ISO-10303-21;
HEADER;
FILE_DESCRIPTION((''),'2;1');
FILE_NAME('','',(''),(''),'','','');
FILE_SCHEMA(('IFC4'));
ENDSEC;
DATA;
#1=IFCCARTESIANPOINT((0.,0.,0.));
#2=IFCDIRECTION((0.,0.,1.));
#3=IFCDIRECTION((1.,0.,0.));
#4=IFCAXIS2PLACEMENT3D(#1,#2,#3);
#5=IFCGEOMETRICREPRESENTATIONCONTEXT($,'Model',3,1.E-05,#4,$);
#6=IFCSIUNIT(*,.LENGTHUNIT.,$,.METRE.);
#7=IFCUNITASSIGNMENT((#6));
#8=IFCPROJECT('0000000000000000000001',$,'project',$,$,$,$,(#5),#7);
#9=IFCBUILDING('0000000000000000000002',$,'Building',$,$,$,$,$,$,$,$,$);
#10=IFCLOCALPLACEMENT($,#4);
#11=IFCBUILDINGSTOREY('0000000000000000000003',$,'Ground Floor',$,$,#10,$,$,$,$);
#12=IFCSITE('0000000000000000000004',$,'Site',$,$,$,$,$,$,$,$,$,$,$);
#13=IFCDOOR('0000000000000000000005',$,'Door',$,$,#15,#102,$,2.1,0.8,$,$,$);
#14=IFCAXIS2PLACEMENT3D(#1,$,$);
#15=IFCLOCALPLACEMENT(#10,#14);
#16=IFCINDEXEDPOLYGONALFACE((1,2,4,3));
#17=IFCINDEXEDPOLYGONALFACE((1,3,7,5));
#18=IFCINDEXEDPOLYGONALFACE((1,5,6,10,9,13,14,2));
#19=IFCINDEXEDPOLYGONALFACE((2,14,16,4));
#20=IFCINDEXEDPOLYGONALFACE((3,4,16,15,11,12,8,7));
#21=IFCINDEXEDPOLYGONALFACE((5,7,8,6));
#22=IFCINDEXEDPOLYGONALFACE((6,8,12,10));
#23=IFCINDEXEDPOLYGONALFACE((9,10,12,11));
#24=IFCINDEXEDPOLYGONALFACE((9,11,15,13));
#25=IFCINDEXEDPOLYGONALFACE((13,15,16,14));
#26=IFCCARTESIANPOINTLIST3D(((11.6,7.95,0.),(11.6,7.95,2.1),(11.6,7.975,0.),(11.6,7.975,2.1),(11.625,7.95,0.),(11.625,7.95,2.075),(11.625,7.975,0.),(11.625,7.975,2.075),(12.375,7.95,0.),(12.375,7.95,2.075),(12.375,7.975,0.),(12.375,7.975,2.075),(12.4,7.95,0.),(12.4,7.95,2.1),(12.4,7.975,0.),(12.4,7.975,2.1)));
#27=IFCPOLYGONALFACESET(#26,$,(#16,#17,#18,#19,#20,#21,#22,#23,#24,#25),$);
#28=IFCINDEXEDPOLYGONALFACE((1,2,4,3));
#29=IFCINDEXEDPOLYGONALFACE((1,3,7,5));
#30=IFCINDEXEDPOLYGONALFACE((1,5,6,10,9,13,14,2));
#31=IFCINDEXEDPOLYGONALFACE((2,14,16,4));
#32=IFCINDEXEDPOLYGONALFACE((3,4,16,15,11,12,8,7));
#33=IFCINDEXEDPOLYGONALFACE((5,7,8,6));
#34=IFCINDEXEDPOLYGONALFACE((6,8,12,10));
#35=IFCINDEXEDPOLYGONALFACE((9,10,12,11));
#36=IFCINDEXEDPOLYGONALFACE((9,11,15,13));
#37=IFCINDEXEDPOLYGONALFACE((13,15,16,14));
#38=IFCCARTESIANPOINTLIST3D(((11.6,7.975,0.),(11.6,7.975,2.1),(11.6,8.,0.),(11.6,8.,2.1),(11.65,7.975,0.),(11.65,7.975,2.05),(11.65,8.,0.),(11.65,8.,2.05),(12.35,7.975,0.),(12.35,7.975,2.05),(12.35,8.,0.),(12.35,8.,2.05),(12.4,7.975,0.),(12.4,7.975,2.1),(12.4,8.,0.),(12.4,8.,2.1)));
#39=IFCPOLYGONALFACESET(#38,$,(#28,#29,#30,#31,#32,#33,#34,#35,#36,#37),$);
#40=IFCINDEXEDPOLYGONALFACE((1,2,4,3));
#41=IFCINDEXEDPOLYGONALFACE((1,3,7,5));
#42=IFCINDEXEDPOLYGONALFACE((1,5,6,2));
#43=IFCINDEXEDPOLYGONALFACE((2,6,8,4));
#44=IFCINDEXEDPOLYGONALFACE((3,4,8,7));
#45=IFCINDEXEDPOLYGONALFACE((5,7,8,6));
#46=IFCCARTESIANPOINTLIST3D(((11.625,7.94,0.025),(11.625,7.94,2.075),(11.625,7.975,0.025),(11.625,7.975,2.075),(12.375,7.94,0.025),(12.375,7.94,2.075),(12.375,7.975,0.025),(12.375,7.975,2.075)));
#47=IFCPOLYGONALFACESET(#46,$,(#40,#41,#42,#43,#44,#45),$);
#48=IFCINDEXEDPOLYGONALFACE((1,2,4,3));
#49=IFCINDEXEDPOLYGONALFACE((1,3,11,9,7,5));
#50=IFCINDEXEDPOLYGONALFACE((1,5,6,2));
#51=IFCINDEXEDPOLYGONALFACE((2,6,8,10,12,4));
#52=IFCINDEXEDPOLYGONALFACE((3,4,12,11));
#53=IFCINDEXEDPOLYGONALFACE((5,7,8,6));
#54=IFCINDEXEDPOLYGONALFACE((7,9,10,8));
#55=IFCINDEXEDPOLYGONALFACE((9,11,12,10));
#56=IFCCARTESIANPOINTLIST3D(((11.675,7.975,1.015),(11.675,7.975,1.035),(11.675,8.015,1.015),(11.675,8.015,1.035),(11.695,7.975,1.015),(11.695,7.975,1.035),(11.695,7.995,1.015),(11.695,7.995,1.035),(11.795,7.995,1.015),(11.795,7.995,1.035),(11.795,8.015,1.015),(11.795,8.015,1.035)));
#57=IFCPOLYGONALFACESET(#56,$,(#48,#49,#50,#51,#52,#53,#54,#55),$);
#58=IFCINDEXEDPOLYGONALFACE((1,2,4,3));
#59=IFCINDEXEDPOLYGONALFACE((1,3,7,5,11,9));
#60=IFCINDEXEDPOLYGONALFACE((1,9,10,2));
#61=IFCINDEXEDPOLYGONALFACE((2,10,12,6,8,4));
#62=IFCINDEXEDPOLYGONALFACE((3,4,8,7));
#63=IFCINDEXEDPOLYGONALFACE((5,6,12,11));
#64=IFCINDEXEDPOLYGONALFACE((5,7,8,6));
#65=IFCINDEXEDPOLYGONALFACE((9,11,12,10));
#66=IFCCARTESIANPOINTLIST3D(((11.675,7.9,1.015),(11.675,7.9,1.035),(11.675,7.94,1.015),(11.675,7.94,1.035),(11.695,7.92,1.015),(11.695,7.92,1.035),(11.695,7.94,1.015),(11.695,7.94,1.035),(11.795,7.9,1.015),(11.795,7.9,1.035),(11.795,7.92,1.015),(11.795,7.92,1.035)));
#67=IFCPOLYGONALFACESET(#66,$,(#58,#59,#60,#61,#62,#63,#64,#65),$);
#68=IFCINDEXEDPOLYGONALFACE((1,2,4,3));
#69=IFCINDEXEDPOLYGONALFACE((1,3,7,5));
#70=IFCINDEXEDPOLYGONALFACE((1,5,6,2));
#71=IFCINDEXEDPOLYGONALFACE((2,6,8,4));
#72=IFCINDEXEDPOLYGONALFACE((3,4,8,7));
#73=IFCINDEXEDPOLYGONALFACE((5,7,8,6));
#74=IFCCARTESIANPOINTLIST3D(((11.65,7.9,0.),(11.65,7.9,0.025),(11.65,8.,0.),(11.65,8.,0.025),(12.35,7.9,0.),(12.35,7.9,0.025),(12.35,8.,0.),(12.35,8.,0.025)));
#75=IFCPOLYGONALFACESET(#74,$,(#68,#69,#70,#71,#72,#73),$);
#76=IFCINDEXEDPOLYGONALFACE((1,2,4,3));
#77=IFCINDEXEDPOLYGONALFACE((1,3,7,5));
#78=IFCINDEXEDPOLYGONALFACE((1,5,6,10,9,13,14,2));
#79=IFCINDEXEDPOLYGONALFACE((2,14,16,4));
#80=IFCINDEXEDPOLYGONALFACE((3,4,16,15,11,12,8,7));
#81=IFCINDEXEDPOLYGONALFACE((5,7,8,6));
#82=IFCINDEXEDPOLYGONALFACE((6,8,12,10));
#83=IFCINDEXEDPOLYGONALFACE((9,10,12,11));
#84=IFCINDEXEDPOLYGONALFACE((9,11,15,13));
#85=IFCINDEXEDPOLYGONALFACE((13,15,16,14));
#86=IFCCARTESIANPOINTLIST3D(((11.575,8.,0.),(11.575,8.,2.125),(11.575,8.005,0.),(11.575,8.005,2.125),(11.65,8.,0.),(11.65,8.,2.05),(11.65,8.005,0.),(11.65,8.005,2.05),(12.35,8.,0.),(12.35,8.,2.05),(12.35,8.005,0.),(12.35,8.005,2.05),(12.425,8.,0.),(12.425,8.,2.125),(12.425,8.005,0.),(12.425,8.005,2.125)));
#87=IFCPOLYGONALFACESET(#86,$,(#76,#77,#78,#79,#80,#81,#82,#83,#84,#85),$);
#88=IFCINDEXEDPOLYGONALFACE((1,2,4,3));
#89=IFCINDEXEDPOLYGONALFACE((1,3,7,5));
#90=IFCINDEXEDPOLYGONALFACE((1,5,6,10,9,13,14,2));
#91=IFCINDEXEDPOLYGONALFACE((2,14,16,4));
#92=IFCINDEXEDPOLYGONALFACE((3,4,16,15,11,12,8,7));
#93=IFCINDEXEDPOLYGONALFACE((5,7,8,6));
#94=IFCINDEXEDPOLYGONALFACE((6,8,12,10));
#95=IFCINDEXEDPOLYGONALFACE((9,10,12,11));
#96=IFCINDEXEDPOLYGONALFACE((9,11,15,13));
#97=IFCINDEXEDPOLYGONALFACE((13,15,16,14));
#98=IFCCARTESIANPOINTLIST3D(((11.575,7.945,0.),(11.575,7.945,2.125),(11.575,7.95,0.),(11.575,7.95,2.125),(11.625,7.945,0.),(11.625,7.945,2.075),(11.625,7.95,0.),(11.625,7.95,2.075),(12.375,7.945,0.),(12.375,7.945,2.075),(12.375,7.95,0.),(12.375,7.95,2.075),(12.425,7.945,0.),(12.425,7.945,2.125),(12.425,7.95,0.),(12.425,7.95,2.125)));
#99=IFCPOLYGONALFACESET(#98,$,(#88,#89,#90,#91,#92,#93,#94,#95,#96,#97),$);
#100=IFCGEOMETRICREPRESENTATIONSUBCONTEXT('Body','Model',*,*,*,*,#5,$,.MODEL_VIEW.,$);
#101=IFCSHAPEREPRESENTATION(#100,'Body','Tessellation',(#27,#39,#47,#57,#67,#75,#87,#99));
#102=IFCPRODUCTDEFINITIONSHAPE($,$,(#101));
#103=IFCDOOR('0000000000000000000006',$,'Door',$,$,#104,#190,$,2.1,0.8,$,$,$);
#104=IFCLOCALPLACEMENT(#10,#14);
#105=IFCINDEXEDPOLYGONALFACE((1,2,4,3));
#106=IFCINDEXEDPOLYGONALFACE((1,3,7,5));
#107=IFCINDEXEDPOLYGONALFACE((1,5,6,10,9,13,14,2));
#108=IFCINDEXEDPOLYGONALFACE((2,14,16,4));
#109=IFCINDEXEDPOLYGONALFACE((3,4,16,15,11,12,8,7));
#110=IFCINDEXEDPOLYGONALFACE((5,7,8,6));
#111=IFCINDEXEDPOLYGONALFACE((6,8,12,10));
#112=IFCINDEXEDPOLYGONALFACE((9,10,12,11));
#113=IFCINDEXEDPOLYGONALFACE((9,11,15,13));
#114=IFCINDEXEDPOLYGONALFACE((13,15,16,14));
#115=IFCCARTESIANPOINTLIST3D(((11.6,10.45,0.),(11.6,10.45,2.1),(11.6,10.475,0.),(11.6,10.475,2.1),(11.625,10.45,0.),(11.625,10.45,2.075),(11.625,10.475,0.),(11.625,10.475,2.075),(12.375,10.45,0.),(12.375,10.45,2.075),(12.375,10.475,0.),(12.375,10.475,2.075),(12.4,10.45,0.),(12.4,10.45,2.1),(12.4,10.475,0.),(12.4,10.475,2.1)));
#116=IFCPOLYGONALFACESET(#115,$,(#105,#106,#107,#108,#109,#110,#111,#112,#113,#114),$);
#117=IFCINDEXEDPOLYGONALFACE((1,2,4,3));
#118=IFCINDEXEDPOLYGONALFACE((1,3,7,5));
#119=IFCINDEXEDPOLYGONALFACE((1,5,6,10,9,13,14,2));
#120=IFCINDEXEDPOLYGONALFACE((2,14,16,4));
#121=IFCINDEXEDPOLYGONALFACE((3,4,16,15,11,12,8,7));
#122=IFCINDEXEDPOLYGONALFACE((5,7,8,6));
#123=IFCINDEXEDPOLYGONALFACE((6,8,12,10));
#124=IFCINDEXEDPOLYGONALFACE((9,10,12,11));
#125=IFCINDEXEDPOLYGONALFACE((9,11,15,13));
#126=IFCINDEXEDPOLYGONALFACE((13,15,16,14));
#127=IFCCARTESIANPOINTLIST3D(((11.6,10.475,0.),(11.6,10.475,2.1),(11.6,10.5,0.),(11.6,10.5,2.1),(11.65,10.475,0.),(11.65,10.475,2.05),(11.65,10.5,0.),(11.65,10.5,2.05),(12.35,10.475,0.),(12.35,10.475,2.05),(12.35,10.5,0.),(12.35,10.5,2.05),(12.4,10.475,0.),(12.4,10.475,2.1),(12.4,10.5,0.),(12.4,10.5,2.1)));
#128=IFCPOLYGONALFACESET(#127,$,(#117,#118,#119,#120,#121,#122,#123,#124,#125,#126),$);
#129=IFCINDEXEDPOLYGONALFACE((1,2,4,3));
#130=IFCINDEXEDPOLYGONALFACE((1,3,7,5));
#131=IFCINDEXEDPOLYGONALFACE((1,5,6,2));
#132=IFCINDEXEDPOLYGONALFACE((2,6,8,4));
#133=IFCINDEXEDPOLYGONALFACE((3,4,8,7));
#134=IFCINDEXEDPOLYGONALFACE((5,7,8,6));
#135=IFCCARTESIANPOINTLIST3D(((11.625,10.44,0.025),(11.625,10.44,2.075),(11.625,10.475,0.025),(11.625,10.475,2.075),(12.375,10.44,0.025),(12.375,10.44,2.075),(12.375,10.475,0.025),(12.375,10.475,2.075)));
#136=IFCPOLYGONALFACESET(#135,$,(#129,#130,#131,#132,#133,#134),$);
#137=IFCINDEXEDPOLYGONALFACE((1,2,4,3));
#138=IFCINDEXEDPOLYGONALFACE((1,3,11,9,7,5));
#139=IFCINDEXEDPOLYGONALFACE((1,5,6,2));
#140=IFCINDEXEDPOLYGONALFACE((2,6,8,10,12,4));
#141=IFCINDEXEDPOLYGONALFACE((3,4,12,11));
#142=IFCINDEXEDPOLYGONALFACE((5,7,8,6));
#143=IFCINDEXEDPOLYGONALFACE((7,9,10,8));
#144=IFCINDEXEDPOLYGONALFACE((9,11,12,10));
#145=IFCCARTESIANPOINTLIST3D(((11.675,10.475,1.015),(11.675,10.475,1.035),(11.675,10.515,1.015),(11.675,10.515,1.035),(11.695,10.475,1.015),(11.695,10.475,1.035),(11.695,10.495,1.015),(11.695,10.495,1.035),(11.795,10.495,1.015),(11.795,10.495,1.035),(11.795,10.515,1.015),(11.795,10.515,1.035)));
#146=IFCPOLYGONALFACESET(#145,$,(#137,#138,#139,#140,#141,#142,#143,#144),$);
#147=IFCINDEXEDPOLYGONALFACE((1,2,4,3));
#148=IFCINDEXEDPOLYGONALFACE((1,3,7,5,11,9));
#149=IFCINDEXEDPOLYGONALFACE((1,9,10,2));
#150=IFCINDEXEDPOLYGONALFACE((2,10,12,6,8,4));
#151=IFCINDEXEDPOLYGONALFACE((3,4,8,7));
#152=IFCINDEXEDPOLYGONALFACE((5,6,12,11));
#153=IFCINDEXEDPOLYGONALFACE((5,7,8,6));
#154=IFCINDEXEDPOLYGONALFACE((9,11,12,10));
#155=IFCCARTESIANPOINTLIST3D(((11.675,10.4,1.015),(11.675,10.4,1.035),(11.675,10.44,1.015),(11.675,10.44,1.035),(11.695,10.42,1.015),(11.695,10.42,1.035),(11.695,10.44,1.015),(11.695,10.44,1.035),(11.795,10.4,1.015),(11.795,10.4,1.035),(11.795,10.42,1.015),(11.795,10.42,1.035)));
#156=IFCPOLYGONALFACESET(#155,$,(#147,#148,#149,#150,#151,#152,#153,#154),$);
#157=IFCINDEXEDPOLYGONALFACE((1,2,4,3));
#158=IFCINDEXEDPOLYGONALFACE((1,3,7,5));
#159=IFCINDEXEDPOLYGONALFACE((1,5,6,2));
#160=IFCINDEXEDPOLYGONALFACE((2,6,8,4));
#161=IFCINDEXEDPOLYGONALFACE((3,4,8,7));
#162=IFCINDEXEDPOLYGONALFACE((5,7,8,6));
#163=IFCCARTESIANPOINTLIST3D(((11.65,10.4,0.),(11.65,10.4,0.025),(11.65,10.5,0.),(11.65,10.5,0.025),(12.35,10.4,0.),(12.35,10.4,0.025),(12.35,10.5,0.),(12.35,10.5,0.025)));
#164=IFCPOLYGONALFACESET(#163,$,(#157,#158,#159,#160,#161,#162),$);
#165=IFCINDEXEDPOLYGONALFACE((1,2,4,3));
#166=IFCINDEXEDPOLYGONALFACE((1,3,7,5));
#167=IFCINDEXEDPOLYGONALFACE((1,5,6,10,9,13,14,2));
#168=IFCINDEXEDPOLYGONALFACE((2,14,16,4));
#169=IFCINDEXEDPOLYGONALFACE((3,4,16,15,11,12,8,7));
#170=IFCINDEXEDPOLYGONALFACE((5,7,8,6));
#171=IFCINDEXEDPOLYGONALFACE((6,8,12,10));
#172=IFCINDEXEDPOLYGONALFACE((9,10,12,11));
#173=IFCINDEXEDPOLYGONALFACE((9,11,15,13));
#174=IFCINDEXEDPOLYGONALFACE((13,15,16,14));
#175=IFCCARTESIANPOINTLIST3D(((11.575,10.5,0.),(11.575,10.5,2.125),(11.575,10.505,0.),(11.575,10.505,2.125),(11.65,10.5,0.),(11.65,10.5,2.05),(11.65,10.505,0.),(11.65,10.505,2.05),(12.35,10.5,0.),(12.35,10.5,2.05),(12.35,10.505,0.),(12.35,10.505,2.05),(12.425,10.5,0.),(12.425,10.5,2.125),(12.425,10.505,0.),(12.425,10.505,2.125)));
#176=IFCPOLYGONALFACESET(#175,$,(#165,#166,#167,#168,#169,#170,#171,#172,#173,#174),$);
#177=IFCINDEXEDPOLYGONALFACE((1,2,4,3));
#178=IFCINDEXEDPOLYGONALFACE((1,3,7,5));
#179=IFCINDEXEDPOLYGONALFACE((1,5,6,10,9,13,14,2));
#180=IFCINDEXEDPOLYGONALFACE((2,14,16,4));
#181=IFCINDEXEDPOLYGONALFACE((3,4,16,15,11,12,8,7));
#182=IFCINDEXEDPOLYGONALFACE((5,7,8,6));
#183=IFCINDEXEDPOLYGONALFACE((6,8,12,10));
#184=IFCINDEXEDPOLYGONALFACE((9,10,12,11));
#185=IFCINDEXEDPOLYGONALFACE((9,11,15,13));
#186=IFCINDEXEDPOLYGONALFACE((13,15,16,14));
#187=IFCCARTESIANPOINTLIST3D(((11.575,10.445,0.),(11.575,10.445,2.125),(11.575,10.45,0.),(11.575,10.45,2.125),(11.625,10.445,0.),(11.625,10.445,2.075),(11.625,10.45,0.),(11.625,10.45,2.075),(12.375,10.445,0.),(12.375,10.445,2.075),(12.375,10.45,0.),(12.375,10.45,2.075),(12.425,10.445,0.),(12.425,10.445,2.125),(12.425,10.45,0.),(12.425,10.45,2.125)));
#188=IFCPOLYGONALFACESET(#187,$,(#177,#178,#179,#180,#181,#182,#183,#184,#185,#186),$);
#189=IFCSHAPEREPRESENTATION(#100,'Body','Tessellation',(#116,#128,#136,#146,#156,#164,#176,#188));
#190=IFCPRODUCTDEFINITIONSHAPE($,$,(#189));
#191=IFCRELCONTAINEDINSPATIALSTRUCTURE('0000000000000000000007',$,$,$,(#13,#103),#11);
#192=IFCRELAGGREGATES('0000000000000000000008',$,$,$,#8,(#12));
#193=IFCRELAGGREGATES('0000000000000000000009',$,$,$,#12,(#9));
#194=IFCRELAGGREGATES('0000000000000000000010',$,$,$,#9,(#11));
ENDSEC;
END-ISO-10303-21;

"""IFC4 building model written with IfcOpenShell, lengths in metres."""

from ifc_helpers import new_model, si_unit, frame, origin_with_axes, place, context, subcontext, project, spatial, line, indexed_curve, outline, extrude, element, save


model = new_model("IFC4")

# Units and contexts
model_context = context("Model", 3, precision=1e-05, world=origin_with_axes())
body_context = subcontext(model_context, "Body", "Model", "MODEL_VIEW")
ifc_project = project(units=[si_unit("LENGTHUNIT", "METRE")], contexts=[model_context])

# Site, building, storey
site = spatial("IfcSite", under=ifc_project, Name="Site")
building = spatial("IfcBuilding", under=site, Name="Building")
storey_placement = place(None, origin_with_axes())
storey = spatial("IfcBuildingStorey", under=building, at=storey_placement, Name="Ground Floor")

# Doors
door_1_placement = place(storey_placement, frame((12.4, 8.0, 0.0), z_axis=(0.0, 0.0, 1.0), x_axis=(-1.0, 0.0, 0.0)))
element("IfcDoor", 1, at=door_1_placement, inside=storey, Name="Door", OverallHeight=2.1, OverallWidth=0.8, context=body_context, shape_type="SweptSolid", body=[
    extrude(outline(indexed_curve([(0.0, 0.0), (0.0, 2.1), (0.8, 2.1), (0.8, 0.0), (0.775, 0.0), (0.775, 2.075), (0.025, 2.075), (0.025, 0.0)], segments=[line(1, 2, 3, 4, 5, 6, 7, 8, 1)])), frame((0.0, 0.025, 0.0), z_axis=(0.0, -1.0, 0.0), x_axis=(1.0, 0.0, 0.0)), (0.0, 0.0, -1.0), 0.025),
    extrude(outline(indexed_curve([(0.0, 0.0), (0.0, 2.1), (0.8, 2.1), (0.8, 0.0), (0.75, 0.0), (0.75, 2.05), (0.05, 2.05), (0.05, 0.0)], segments=[line(1, 2, 3, 4, 5, 6, 7, 8, 1)])), frame((0.0, 0.0, 0.0), z_axis=(0.0, -1.0, 0.0), x_axis=(1.0, 0.0, 0.0)), (0.0, 0.0, -1.0), 0.025),
    extrude(outline(indexed_curve([(0.0, 0.0), (0.75, 0.0), (0.75, 0.035), (0.0, 0.035)], segments=[line(1, 2, 3, 4, 1)])), frame((0.025, 0.025, 0.025), z_axis=(0.0, 0.0, 1.0), x_axis=(1.0, 0.0, 0.0)), (0.0, 0.0, 1.0), 2.05),
    extrude(outline(indexed_curve([(0.0, 0.0), (0.0, -0.04), (-0.12, -0.04), (-0.12, -0.02), (-0.02, -0.02), (-0.02, 0.0)], segments=[line(1, 2, 3, 4, 5, 6, 1)])), frame((0.725, 0.025, 1.015), z_axis=(0.0, 0.0, 1.0), x_axis=(1.0, 0.0, 0.0)), (0.0, 0.0, 1.0), 0.02),
    extrude(outline(indexed_curve([(0.0, 0.0), (0.0, 0.04), (-0.12, 0.04), (-0.12, 0.02), (-0.02, 0.02), (-0.02, 0.0)], segments=[line(1, 2, 3, 4, 5, 6, 1)])), frame((0.725, 0.06, 1.015), z_axis=(0.0, 0.0, 1.0), x_axis=(1.0, 0.0, 0.0)), (0.0, 0.0, 1.0), 0.02),
    extrude(outline(indexed_curve([(0.0, 0.0), (0.7, 0.0), (0.7, 0.1), (0.0, 0.1)], segments=[line(1, 2, 3, 4, 1)])), frame((0.05, 0.0, 0.0), z_axis=(0.0, 0.0, 1.0), x_axis=(1.0, 0.0, 0.0)), (0.0, 0.0, 1.0), 0.025),
    extrude(outline(indexed_curve([(0.0, 0.0), (0.0, 2.125), (0.85, 2.125), (0.85, 0.0), (0.775, 0.0), (0.775, 2.05), (0.075, 2.05), (0.075, 0.0)], segments=[line(1, 2, 3, 4, 5, 6, 7, 8, 1)])), frame((-0.025, -0.005, 0.0), z_axis=(0.0, -1.0, 0.0), x_axis=(1.0, 0.0, 0.0)), (0.0, 0.0, -1.0), 0.005),
    extrude(outline(indexed_curve([(0.0, 0.0), (0.0, 2.125), (0.85, 2.125), (0.85, 0.0), (0.8, 0.0), (0.8, 2.075), (0.05, 2.075), (0.05, 0.0)], segments=[line(1, 2, 3, 4, 5, 6, 7, 8, 1)])), frame((-0.025, 0.05, 0.0), z_axis=(0.0, -1.0, 0.0), x_axis=(1.0, 0.0, 0.0)), (0.0, 0.0, -1.0), 0.005),
])
door_2_placement = place(storey_placement, frame((12.4, 10.5, 0.0), z_axis=(0.0, 0.0, 1.0), x_axis=(-1.0, 0.0, 0.0)))
element("IfcDoor", 2, at=door_2_placement, inside=storey, Name="Door", OverallHeight=2.1, OverallWidth=0.8, context=body_context, shape_type="SweptSolid", body=[
    extrude(outline(indexed_curve([(0.0, 0.0), (0.0, 2.1), (0.8, 2.1), (0.8, 0.0), (0.775, 0.0), (0.775, 2.075), (0.025, 2.075), (0.025, 0.0)], segments=[line(1, 2, 3, 4, 5, 6, 7, 8, 1)])), frame((0.0, 0.025, 0.0), z_axis=(0.0, -1.0, 0.0), x_axis=(1.0, 0.0, 0.0)), (0.0, 0.0, -1.0), 0.025),
    extrude(outline(indexed_curve([(0.0, 0.0), (0.0, 2.1), (0.8, 2.1), (0.8, 0.0), (0.75, 0.0), (0.75, 2.05), (0.05, 2.05), (0.05, 0.0)], segments=[line(1, 2, 3, 4, 5, 6, 7, 8, 1)])), frame((0.0, 0.0, 0.0), z_axis=(0.0, -1.0, 0.0), x_axis=(1.0, 0.0, 0.0)), (0.0, 0.0, -1.0), 0.025),
    extrude(outline(indexed_curve([(0.0, 0.0), (0.75, 0.0), (0.75, 0.035), (0.0, 0.035)], segments=[line(1, 2, 3, 4, 1)])), frame((0.025, 0.025, 0.025), z_axis=(0.0, 0.0, 1.0), x_axis=(1.0, 0.0, 0.0)), (0.0, 0.0, 1.0), 2.05),
    extrude(outline(indexed_curve([(0.0, 0.0), (0.0, -0.04), (-0.12, -0.04), (-0.12, -0.02), (-0.02, -0.02), (-0.02, 0.0)], segments=[line(1, 2, 3, 4, 5, 6, 1)])), frame((0.725, 0.025, 1.015), z_axis=(0.0, 0.0, 1.0), x_axis=(1.0, 0.0, 0.0)), (0.0, 0.0, 1.0), 0.02),
    extrude(outline(indexed_curve([(0.0, 0.0), (0.0, 0.04), (-0.12, 0.04), (-0.12, 0.02), (-0.02, 0.02), (-0.02, 0.0)], segments=[line(1, 2, 3, 4, 5, 6, 1)])), frame((0.725, 0.06, 1.015), z_axis=(0.0, 0.0, 1.0), x_axis=(1.0, 0.0, 0.0)), (0.0, 0.0, 1.0), 0.02),
    extrude(outline(indexed_curve([(0.0, 0.0), (0.7, 0.0), (0.7, 0.1), (0.0, 0.1)], segments=[line(1, 2, 3, 4, 1)])), frame((0.05, 0.0, 0.0), z_axis=(0.0, 0.0, 1.0), x_axis=(1.0, 0.0, 0.0)), (0.0, 0.0, 1.0), 0.025),
    extrude(outline(indexed_curve([(0.0, 0.0), (0.0, 2.125), (0.85, 2.125), (0.85, 0.0), (0.775, 0.0), (0.775, 2.05), (0.075, 2.05), (0.075, 0.0)], segments=[line(1, 2, 3, 4, 5, 6, 7, 8, 1)])), frame((-0.025, -0.005, 0.0), z_axis=(0.0, -1.0, 0.0), x_axis=(1.0, 0.0, 0.0)), (0.0, 0.0, -1.0), 0.005),
    extrude(outline(indexed_curve([(0.0, 0.0), (0.0, 2.125), (0.85, 2.125), (0.85, 0.0), (0.8, 0.0), (0.8, 2.075), (0.05, 2.075), (0.05, 0.0)], segments=[line(1, 2, 3, 4, 5, 6, 7, 8, 1)])), frame((-0.025, 0.05, 0.0), z_axis=(0.0, -1.0, 0.0), x_axis=(1.0, 0.0, 0.0)), (0.0, 0.0, -1.0), 0.005),
])

save(model, "model.ifc")
